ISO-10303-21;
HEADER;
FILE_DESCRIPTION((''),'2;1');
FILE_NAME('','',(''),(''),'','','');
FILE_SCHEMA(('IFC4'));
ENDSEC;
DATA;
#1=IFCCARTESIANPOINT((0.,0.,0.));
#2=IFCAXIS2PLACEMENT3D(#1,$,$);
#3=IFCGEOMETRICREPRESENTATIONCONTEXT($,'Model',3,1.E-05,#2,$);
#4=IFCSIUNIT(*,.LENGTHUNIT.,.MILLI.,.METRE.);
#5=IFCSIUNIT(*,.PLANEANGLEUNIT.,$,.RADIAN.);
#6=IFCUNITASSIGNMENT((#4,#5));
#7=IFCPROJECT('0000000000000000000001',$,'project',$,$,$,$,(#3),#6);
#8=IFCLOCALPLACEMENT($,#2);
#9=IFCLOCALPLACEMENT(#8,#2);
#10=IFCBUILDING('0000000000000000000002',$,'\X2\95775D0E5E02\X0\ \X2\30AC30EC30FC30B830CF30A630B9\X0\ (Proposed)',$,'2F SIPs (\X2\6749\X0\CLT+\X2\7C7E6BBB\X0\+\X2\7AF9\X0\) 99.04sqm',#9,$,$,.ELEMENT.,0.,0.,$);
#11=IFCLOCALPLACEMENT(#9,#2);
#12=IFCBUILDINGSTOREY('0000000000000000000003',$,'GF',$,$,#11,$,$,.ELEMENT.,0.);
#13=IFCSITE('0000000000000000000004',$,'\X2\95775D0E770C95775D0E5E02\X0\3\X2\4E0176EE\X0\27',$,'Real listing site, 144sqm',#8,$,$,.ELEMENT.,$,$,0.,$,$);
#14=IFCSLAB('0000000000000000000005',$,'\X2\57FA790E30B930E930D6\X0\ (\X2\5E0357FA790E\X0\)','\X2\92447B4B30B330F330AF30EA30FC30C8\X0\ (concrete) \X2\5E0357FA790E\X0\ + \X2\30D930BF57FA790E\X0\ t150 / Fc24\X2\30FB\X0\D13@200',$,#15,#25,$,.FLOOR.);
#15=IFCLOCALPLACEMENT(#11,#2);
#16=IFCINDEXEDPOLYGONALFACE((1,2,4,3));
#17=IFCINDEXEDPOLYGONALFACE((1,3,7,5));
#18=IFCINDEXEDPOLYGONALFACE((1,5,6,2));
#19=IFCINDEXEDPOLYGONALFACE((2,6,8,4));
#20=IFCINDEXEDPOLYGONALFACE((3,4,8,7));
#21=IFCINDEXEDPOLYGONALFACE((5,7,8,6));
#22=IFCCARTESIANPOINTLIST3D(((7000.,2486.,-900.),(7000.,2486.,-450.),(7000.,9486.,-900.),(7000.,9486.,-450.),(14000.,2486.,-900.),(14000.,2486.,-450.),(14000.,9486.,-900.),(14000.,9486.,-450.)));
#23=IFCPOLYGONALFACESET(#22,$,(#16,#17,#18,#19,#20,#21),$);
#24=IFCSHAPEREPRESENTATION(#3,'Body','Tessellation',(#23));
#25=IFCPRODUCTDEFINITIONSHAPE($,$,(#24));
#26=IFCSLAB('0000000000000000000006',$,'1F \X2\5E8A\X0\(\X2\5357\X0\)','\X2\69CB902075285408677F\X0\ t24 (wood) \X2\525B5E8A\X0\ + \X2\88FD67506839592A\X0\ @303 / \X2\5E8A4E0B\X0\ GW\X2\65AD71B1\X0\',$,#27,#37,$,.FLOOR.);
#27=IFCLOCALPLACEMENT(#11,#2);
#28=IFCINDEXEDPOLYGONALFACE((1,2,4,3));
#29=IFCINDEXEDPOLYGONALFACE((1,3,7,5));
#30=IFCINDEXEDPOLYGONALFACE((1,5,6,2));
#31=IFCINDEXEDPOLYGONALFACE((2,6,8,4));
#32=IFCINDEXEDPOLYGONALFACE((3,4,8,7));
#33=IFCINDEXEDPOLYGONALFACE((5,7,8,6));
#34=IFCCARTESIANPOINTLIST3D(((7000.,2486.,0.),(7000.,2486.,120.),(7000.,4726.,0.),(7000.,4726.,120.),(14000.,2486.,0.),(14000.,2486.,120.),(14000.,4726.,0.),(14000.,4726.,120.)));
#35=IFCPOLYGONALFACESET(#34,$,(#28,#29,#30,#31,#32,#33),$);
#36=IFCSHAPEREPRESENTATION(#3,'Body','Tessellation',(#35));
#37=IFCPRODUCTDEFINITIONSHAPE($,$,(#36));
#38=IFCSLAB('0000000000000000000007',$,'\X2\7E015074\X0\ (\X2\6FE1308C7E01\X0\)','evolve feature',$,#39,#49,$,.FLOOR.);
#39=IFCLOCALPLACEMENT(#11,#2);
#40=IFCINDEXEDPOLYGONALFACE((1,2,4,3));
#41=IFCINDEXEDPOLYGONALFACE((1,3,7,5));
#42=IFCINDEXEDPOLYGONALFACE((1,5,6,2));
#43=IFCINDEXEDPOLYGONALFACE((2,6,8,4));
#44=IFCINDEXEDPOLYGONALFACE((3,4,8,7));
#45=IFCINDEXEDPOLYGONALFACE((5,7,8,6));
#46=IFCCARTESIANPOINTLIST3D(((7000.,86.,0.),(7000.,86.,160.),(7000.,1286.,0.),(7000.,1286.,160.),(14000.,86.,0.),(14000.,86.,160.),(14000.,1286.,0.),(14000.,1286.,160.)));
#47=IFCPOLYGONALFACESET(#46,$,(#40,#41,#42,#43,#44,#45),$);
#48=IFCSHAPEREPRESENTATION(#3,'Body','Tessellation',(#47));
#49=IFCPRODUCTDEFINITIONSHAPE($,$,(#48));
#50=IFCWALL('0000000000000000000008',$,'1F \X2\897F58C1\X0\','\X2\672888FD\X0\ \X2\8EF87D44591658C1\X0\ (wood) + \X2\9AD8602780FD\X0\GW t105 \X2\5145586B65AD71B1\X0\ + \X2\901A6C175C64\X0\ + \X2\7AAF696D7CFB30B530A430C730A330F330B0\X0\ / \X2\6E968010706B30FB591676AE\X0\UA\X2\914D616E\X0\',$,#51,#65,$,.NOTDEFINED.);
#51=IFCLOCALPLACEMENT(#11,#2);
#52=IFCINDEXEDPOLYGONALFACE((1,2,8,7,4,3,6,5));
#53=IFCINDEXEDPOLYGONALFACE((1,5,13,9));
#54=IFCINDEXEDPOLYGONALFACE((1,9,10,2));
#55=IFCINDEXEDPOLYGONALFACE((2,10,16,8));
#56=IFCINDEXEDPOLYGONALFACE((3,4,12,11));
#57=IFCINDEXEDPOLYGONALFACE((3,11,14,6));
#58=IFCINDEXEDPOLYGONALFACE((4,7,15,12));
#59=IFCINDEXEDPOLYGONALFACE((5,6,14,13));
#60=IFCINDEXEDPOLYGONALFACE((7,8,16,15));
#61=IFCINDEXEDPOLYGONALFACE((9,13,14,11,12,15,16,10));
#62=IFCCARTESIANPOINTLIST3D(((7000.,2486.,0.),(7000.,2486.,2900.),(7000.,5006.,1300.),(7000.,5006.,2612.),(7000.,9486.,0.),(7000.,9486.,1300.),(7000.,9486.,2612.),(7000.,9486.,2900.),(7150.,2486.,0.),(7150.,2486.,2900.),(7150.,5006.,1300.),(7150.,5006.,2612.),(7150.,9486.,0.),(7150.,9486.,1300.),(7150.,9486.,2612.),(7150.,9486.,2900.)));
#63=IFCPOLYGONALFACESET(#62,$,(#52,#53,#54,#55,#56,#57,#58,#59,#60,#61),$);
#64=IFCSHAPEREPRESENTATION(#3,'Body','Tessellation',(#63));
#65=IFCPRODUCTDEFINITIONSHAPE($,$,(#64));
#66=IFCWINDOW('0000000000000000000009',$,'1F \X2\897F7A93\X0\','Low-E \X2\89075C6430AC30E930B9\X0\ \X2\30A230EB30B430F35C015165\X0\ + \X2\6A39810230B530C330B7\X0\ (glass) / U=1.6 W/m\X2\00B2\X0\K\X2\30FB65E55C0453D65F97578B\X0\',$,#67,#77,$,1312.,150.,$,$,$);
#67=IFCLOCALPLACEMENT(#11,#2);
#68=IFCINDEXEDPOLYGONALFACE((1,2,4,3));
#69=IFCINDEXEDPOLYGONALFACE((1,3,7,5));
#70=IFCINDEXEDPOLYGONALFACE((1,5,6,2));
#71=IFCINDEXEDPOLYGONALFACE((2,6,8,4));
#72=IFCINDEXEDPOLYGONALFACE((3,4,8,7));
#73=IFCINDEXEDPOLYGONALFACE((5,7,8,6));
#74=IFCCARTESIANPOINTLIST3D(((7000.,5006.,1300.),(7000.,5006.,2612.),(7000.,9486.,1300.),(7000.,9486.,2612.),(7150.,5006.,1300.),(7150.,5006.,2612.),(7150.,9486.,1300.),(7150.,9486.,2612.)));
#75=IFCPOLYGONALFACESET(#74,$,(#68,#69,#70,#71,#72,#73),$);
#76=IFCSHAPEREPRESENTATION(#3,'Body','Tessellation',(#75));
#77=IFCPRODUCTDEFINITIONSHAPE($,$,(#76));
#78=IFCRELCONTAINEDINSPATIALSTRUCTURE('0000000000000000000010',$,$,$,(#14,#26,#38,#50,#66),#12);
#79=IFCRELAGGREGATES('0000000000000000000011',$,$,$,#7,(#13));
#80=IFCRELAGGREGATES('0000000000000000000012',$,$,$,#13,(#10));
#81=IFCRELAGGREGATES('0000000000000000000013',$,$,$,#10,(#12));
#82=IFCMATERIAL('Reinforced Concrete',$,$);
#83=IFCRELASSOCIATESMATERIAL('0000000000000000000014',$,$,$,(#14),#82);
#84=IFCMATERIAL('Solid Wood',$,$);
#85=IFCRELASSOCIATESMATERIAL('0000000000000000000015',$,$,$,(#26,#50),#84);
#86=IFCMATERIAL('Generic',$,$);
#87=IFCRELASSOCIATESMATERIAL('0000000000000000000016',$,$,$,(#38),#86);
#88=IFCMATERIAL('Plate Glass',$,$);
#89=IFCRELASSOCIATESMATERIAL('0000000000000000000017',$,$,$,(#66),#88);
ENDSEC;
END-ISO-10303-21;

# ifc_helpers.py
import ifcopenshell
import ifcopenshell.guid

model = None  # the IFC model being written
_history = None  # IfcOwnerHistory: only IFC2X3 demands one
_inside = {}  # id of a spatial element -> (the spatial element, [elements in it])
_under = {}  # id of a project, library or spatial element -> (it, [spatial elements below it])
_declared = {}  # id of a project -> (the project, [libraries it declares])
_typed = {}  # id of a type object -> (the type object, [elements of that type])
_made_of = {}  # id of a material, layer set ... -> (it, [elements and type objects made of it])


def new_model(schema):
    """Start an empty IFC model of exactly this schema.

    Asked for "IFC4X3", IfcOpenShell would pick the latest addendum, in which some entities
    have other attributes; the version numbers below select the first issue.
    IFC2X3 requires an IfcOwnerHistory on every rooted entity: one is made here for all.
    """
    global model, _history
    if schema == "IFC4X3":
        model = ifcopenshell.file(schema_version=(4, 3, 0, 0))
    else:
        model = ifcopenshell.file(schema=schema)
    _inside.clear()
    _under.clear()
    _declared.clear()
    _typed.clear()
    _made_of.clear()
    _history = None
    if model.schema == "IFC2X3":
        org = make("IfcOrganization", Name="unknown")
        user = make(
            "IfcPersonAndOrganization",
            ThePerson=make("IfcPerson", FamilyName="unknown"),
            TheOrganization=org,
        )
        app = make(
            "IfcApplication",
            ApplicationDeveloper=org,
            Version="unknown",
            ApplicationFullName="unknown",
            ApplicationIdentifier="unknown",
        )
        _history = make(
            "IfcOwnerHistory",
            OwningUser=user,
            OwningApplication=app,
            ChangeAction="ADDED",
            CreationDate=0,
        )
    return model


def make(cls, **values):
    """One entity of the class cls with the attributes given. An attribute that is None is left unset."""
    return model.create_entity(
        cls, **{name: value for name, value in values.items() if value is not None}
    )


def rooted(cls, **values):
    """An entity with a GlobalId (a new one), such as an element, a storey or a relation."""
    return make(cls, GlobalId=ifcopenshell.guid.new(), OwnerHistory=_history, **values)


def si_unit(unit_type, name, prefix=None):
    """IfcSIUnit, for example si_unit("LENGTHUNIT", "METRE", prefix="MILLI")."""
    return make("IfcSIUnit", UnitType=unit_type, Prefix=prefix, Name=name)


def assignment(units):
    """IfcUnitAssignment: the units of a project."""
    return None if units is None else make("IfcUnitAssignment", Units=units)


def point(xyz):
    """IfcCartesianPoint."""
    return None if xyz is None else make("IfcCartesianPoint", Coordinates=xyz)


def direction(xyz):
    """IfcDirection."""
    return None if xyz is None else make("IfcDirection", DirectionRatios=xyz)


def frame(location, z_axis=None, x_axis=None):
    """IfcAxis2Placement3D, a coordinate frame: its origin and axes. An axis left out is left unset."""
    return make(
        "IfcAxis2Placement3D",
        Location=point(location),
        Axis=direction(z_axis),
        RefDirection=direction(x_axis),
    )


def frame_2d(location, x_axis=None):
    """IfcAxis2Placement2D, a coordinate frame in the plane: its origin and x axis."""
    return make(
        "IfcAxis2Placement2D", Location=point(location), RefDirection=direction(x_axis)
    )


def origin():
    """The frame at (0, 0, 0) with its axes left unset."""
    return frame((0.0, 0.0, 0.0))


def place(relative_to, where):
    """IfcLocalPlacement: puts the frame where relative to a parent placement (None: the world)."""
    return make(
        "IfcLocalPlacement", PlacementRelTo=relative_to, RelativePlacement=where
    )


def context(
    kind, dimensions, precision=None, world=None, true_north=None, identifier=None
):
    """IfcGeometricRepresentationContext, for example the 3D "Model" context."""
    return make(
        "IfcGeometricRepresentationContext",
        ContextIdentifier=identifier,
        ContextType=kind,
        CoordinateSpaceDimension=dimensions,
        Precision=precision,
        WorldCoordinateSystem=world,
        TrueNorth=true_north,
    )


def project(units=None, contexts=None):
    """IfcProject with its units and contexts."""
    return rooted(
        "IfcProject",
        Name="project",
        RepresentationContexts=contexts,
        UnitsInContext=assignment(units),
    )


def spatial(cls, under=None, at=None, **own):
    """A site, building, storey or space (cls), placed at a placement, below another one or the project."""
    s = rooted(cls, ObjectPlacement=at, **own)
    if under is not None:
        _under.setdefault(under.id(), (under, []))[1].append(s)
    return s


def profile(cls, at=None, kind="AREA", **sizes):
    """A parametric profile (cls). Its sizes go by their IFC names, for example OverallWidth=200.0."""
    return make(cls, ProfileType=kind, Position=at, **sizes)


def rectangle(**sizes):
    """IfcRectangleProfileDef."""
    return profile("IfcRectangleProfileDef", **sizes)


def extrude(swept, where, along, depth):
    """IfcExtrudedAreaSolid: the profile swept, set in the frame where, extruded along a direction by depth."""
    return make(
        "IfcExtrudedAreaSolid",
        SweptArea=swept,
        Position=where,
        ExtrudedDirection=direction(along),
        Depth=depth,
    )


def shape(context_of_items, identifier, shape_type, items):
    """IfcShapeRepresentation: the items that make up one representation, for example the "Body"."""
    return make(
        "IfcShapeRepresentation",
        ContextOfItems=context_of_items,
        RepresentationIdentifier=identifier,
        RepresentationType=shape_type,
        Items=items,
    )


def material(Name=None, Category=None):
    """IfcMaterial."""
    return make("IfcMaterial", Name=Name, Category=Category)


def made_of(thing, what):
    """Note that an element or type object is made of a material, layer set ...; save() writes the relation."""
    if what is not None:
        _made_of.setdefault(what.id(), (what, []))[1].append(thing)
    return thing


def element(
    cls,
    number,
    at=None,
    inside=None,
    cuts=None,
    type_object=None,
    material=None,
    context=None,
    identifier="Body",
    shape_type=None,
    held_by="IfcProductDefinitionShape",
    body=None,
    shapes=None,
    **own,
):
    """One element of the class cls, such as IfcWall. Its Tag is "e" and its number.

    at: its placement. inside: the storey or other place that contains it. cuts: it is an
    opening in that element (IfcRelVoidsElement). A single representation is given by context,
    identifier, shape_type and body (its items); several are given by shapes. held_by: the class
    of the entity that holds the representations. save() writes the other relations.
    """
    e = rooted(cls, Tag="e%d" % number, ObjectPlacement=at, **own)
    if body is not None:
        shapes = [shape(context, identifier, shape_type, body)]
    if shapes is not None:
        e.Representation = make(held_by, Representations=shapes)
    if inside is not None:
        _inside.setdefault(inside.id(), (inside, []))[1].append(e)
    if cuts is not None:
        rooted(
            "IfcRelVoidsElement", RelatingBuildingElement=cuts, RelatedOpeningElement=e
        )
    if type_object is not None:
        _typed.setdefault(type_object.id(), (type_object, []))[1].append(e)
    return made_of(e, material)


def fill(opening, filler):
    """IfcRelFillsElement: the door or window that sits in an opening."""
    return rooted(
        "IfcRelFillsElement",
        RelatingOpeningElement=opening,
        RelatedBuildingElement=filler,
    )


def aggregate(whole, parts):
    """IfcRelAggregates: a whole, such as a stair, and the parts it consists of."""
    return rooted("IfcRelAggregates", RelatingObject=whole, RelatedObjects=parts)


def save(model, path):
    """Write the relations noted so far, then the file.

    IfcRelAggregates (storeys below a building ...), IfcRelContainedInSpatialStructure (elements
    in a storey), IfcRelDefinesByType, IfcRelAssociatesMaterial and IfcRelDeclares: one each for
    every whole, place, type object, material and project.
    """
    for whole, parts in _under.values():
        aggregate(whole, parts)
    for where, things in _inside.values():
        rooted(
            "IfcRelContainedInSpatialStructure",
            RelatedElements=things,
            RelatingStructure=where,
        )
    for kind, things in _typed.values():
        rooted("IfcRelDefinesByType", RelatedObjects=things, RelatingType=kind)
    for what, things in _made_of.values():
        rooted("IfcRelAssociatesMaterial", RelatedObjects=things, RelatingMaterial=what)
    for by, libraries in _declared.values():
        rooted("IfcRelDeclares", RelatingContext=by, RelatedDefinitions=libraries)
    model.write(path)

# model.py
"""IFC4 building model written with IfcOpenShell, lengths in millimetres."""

from ifc_helpers import new_model, si_unit, frame, frame_2d, origin, place, context, project, spatial, rectangle, extrude, material, element, fill, save


model = new_model("IFC4")

# Units and contexts
model_context = context("Model", 3, precision=1e-05, world=origin())
ifc_project = project(units=[si_unit("LENGTHUNIT", "METRE", prefix="MILLI"), si_unit("PLANEANGLEUNIT", "RADIAN")], contexts=[model_context])

# Site, building, storey
site_placement = place(None, origin())
site = spatial("IfcSite", under=ifc_project, at=site_placement, Name="長崎県長崎市3丁目27", ObjectType="Real listing site, 144sqm", CompositionType="ELEMENT", RefElevation=0.0)
building_placement = place(site_placement, origin())
building = spatial("IfcBuilding", under=site, at=building_placement, Name="長崎市 ガレージハウス (Proposed)", ObjectType="2F SIPs (杉CLT+籾殻+竹) 99.04sqm", CompositionType="ELEMENT", ElevationOfRefHeight=0.0, ElevationOfTerrain=0.0)
storey_placement = place(building_placement, origin())
storey = spatial("IfcBuildingStorey", under=building, at=storey_placement, Name="GF", CompositionType="ELEMENT", Elevation=0.0)

# Slabs
ifc_material_1 = material(Name="Reinforced Concrete")
slab_1_placement = place(storey_placement, frame((3500.0, 1243.0, -450.0)))
element("IfcSlab", 1, at=slab_1_placement, inside=storey, material=ifc_material_1, Name="基礎スラブ (布基礎)", Description="鉄筋コンクリート (concrete) 布基礎 + ベタ基礎 t150 / Fc24・D13@200", PredefinedType="FLOOR", context=model_context, shape_type="SweptSolid", body=[
    extrude(rectangle(XDim=7000.0, YDim=7000.0, at=frame_2d((3500.0, 3500.0))), frame((3500.0, 1243.0, -450.0)), (0.0, 0.0, 1.0), 450.0),
])
ifc_material_2 = material(Name="Solid Wood")
slab_2_placement = place(storey_placement, frame((3500.0, 1243.0, 0.0)))
element("IfcSlab", 2, at=slab_2_placement, inside=storey, material=ifc_material_2, Name="1F 床(南)", Description="構造用合板 t24 (wood) 剛床 + 製材根太 @303 / 床下 GW断熱", PredefinedType="FLOOR", context=model_context, shape_type="SweptSolid", body=[
    extrude(rectangle(XDim=7000.0, YDim=2240.0, at=frame_2d((3500.0, 1120.0))), frame((3500.0, 1243.0, 0.0)), (0.0, 0.0, 1.0), 120.0),
])
ifc_material_3 = material(Name="Generic")
slab_3_placement = place(storey_placement, frame((3500.0, 43.0, 0.0)))
element("IfcSlab", 3, at=slab_3_placement, inside=storey, material=ifc_material_3, Name="縁側 (濡れ縁)", Description="evolve feature", PredefinedType="FLOOR", context=model_context, shape_type="SweptSolid", body=[
    extrude(rectangle(XDim=7000.0, YDim=1200.0, at=frame_2d((3500.0, 600.0))), frame((3500.0, 43.0, 0.0)), (0.0, 0.0, 1.0), 160.0),
])

# Shared definitions
ifc_material_4 = material(Name="Plate Glass")

# Wall, opening, window
wall_1_placement = place(storey_placement, frame((3500.0, 1243.0, 0.0)))
wall_1 = element("IfcWall", 4, at=wall_1_placement, inside=storey, material=ifc_material_2, Name="1F 西壁", Description="木製 軸組外壁 (wood) + 高性能GW t105 充填断熱 + 通気層 + 窯業系サイディング / 準耐火・外皮UA配慮", PredefinedType="NOTDEFINED", context=model_context, shape_type="SweptSolid", body=[
    extrude(rectangle(XDim=150.0, YDim=7000.0, at=frame_2d((75.0, 3500.0))), frame((3500.0, 1243.0, 0.0)), (0.0, 0.0, 1.0), 2900.0),
])
opening_1_placement = place(storey_placement, frame((3500.0, 2503.0, 650.0)))
opening_1 = element("IfcOpeningElement", 5, at=opening_1_placement, cuts=wall_1, PredefinedType="NOTDEFINED", context=model_context, shape_type="SweptSolid", body=[
    extrude(rectangle(XDim=150.0, YDim=4480.0, at=frame_2d((75.0, 2240.0))), frame((3500.0, 2503.0, 650.0)), (0.0, 0.0, 1.0), 1312.0),
])
window_1_placement = place(storey_placement, frame((3500.0, 2503.0, 650.0)))
window_1 = element("IfcWindow", 6, at=window_1_placement, inside=storey, material=ifc_material_4, Name="1F 西窓", Description="Low-E 複層ガラス アルゴン封入 + 樹脂サッシ (glass) / U=1.6 W/m²K・日射取得型", OverallHeight=1312.0, OverallWidth=150.0, context=model_context, shape_type="SweptSolid", body=[
    extrude(rectangle(XDim=150.0, YDim=4480.0, at=frame_2d((75.0, 2240.0))), frame((3500.0, 2503.0, 650.0)), (0.0, 0.0, 1.0), 1312.0),
])
fill(opening_1, window_1)

save(model, "model.ifc")
